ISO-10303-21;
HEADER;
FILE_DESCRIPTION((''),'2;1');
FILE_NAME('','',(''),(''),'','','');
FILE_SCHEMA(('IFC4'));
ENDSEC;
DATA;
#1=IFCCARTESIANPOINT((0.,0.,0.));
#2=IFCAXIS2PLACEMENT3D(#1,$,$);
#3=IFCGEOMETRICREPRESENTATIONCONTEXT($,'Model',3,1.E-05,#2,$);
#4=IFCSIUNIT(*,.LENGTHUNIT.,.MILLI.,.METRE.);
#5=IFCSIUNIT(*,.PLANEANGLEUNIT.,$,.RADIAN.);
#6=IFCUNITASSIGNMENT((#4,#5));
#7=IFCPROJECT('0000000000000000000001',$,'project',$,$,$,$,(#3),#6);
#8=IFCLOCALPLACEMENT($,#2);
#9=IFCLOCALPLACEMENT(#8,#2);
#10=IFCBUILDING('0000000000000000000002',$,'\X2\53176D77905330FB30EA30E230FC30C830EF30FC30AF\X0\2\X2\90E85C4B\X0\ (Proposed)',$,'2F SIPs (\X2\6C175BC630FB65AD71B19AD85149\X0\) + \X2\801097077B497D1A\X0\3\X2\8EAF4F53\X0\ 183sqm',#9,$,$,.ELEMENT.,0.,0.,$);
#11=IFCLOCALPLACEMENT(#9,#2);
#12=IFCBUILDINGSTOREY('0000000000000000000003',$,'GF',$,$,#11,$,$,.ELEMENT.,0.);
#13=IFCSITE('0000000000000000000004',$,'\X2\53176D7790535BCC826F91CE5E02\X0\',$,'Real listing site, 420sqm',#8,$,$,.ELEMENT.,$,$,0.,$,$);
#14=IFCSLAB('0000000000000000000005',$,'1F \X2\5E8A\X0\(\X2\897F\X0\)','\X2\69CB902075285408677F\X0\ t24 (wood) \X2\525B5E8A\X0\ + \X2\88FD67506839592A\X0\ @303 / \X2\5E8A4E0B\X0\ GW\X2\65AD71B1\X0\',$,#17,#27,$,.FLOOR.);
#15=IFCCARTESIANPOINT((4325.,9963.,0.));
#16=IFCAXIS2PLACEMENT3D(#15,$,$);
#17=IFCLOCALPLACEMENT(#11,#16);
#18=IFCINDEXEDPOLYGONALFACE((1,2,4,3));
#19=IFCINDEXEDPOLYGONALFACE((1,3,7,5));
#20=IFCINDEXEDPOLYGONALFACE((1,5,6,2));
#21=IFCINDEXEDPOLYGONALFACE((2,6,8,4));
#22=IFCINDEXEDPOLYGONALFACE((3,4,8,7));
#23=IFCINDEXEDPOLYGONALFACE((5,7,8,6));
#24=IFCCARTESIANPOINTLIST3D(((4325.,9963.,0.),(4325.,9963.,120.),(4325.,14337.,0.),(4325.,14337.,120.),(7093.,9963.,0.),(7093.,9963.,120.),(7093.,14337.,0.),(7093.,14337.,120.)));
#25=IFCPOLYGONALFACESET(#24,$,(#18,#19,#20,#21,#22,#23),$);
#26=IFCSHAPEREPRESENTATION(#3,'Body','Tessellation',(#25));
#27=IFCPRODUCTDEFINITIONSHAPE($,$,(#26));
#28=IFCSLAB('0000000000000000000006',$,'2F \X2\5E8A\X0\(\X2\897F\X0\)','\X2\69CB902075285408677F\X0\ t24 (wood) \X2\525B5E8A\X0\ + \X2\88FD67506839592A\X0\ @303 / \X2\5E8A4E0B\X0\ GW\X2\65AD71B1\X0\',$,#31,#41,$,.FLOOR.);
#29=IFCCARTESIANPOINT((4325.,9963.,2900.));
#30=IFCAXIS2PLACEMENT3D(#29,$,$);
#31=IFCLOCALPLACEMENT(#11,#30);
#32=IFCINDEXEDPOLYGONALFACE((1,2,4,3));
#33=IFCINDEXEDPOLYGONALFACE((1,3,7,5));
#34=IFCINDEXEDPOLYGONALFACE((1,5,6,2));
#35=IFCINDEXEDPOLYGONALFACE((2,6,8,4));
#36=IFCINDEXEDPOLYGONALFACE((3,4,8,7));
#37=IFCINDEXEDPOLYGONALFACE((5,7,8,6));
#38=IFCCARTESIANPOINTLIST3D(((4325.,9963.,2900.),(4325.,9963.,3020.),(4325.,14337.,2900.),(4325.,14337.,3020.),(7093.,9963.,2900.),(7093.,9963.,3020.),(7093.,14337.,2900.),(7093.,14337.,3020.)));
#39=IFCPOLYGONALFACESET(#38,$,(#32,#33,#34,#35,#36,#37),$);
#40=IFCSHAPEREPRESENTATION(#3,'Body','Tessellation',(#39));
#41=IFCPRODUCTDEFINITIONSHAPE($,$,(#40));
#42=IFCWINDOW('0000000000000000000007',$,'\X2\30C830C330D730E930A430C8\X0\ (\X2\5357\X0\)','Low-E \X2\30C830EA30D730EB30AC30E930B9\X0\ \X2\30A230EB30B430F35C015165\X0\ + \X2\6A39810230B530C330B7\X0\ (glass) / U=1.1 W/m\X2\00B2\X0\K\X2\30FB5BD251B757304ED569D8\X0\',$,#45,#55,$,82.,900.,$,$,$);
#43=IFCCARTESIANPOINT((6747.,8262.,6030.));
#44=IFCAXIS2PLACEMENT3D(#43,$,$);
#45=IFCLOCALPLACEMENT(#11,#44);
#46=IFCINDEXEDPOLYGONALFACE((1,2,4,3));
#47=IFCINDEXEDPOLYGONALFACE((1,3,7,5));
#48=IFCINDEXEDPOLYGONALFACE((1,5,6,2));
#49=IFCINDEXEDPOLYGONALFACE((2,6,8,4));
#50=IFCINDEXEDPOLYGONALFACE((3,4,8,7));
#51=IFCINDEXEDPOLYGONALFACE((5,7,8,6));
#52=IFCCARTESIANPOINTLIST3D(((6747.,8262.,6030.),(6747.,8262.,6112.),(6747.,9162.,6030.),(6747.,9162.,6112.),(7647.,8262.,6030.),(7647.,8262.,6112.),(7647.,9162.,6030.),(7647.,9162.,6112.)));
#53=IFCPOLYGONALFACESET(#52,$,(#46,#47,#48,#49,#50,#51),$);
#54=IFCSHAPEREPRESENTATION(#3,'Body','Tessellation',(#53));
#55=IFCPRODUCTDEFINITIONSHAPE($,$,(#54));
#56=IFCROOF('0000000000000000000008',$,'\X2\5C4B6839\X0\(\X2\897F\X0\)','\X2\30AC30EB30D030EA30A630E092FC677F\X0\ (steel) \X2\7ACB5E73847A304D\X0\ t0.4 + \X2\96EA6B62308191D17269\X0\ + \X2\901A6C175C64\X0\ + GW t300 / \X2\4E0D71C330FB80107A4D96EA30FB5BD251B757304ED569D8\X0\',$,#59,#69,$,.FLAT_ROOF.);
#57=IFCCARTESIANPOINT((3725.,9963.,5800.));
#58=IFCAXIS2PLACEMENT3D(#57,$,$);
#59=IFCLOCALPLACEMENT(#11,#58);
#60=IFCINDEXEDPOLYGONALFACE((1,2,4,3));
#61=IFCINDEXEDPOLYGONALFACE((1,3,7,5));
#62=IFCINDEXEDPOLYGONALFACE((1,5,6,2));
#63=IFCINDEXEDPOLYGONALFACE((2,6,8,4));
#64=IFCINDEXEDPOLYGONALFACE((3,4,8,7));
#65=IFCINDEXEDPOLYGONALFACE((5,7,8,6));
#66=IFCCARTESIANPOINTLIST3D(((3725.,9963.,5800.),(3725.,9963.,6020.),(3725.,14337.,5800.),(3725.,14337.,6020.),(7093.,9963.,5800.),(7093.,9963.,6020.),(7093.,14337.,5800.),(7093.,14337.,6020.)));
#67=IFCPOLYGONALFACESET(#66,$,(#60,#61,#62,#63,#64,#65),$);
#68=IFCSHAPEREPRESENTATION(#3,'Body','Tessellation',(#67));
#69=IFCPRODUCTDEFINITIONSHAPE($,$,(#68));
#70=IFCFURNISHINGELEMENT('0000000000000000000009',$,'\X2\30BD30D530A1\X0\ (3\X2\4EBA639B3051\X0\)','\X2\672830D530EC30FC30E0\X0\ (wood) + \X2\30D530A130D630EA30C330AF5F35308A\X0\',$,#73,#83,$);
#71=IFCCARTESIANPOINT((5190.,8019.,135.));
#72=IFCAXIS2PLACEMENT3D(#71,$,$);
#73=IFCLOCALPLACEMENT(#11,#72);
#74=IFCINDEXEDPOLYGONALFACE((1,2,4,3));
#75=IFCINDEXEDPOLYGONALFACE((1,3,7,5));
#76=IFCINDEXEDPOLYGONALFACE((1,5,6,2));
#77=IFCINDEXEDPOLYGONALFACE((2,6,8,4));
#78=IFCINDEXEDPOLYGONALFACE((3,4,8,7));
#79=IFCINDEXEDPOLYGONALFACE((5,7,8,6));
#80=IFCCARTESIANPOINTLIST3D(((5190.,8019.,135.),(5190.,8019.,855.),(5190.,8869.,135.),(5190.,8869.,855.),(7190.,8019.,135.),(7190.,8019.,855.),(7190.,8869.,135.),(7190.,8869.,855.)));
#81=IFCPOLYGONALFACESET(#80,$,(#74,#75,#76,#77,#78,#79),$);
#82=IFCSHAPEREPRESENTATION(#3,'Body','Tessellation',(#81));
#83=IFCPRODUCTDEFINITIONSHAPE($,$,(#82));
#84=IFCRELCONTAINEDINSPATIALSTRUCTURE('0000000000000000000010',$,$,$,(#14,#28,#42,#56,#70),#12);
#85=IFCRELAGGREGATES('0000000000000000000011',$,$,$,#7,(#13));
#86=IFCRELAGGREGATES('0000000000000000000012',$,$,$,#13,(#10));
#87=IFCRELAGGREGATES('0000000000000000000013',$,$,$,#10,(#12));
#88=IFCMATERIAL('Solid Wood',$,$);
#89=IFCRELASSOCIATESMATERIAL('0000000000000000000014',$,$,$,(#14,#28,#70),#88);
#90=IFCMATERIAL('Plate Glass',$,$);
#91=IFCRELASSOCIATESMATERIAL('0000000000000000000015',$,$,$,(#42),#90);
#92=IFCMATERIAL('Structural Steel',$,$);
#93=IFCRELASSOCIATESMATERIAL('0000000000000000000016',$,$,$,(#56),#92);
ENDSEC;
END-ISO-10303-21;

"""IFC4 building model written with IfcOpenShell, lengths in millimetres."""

from ifc_helpers import new_model, si_unit, frame, frame_2d, origin, place, context, project, spatial, rectangle, extrude, material, element, save


model = new_model("IFC4")

# Units and contexts
model_context = context("Model", 3, precision=1e-05, world=origin())
ifc_project = project(units=[si_unit("LENGTHUNIT", "METRE", prefix="MILLI"), si_unit("PLANEANGLEUNIT", "RADIAN")], contexts=[model_context])

# Site, building, storey
site_placement = place(None, origin())
site = spatial("IfcSite", under=ifc_project, at=site_placement, Name="北海道富良野市", ObjectType="Real listing site, 420sqm", CompositionType="ELEMENT", RefElevation=0.0)
building_placement = place(site_placement, origin())
building = spatial("IfcBuilding", under=site, at=building_placement, Name="北海道・リモートワーク2部屋 (Proposed)", ObjectType="2F SIPs (気密・断熱高光) + 耐震等級3躯体 183sqm", CompositionType="ELEMENT", ElevationOfRefHeight=0.0, ElevationOfTerrain=0.0)
storey_placement = place(building_placement, origin())
storey = spatial("IfcBuildingStorey", under=building, at=storey_placement, Name="GF", CompositionType="ELEMENT", Elevation=0.0)

# Shared definitions
ifc_material_1 = material(Name="Solid Wood")

# Slabs
slab_1_placement = place(storey_placement, frame((4325.0, 9963.0, 0.0)))
element("IfcSlab", 1, at=slab_1_placement, inside=storey, material=ifc_material_1, Name="1F 床(西)", Description="構造用合板 t24 (wood) 剛床 + 製材根太 @303 / 床下 GW断熱", PredefinedType="FLOOR", context=model_context, shape_type="SweptSolid", body=[
    extrude(rectangle(XDim=2768.0, YDim=4374.0, at=frame_2d((1384.0, 2187.0))), frame((4325.0, 9963.0, 0.0)), (0.0, 0.0, 1.0), 120.0),
])
slab_2_placement = place(storey_placement, frame((4325.0, 9963.0, 2900.0)))
element("IfcSlab", 2, at=slab_2_placement, inside=storey, material=ifc_material_1, Name="2F 床(西)", Description="構造用合板 t24 (wood) 剛床 + 製材根太 @303 / 床下 GW断熱", PredefinedType="FLOOR", context=model_context, shape_type="SweptSolid", body=[
    extrude(rectangle(XDim=2768.0, YDim=4374.0, at=frame_2d((1384.0, 2187.0))), frame((4325.0, 9963.0, 2900.0)), (0.0, 0.0, 1.0), 120.0),
])

# Window
ifc_material_2 = material(Name="Plate Glass")
window_placement = place(storey_placement, frame((6747.0, 8262.0, 6030.0)))
element("IfcWindow", 3, at=window_placement, inside=storey, material=ifc_material_2, Name="トップライト (南)", Description="Low-E トリプルガラス アルゴン封入 + 樹脂サッシ (glass) / U=1.1 W/m²K・寒冷地仕様", OverallHeight=82.0, OverallWidth=900.0, context=model_context, shape_type="SweptSolid", body=[
    extrude(rectangle(XDim=900.0, YDim=900.0, at=frame_2d((450.0, 450.0))), frame((6747.0, 8262.0, 6030.0)), (0.0, 0.0, 1.0), 82.0),
])

# Roof
ifc_material_3 = material(Name="Structural Steel")
for number, where, name in (
    (4, (3725.0, 9963.0, 5800.0), "屋根(西)"),
):
    element("IfcRoof", number, at=place(storey_placement, frame(where)), inside=storey, material=ifc_material_3, Name=name, Description="ガルバリウム鋼板 (steel) 立平葺き t0.4 + 雪止め金物 + 通気層 + GW t300 / 不燃・耐積雪・寒冷地仕様", PredefinedType="FLAT_ROOF", context=model_context, shape_type="SweptSolid", body=[
        extrude(rectangle(XDim=3368.0, YDim=4374.0, at=frame_2d((1684.0, 2187.0))), frame((3725.0, 9963.0, 5800.0)), (0.0, 0.0, 1.0), 220.0),
    ])

# Furnishing element
furnishing_placement = place(storey_placement, frame((5190.0, 8019.0, 135.0)))
element("IfcFurnishingElement", 5, at=furnishing_placement, inside=storey, material=ifc_material_1, Name="ソファ (3人掛け)", Description="木フレーム (wood) + ファブリック張り", context=model_context, shape_type="SweptSolid", body=[
    extrude(rectangle(XDim=2000.0, YDim=850.0, at=frame_2d((1000.0, 425.0))), frame((5190.0, 8019.0, 135.0)), (0.0, 0.0, 1.0), 720.0),
])

save(model, "model.ifc")
